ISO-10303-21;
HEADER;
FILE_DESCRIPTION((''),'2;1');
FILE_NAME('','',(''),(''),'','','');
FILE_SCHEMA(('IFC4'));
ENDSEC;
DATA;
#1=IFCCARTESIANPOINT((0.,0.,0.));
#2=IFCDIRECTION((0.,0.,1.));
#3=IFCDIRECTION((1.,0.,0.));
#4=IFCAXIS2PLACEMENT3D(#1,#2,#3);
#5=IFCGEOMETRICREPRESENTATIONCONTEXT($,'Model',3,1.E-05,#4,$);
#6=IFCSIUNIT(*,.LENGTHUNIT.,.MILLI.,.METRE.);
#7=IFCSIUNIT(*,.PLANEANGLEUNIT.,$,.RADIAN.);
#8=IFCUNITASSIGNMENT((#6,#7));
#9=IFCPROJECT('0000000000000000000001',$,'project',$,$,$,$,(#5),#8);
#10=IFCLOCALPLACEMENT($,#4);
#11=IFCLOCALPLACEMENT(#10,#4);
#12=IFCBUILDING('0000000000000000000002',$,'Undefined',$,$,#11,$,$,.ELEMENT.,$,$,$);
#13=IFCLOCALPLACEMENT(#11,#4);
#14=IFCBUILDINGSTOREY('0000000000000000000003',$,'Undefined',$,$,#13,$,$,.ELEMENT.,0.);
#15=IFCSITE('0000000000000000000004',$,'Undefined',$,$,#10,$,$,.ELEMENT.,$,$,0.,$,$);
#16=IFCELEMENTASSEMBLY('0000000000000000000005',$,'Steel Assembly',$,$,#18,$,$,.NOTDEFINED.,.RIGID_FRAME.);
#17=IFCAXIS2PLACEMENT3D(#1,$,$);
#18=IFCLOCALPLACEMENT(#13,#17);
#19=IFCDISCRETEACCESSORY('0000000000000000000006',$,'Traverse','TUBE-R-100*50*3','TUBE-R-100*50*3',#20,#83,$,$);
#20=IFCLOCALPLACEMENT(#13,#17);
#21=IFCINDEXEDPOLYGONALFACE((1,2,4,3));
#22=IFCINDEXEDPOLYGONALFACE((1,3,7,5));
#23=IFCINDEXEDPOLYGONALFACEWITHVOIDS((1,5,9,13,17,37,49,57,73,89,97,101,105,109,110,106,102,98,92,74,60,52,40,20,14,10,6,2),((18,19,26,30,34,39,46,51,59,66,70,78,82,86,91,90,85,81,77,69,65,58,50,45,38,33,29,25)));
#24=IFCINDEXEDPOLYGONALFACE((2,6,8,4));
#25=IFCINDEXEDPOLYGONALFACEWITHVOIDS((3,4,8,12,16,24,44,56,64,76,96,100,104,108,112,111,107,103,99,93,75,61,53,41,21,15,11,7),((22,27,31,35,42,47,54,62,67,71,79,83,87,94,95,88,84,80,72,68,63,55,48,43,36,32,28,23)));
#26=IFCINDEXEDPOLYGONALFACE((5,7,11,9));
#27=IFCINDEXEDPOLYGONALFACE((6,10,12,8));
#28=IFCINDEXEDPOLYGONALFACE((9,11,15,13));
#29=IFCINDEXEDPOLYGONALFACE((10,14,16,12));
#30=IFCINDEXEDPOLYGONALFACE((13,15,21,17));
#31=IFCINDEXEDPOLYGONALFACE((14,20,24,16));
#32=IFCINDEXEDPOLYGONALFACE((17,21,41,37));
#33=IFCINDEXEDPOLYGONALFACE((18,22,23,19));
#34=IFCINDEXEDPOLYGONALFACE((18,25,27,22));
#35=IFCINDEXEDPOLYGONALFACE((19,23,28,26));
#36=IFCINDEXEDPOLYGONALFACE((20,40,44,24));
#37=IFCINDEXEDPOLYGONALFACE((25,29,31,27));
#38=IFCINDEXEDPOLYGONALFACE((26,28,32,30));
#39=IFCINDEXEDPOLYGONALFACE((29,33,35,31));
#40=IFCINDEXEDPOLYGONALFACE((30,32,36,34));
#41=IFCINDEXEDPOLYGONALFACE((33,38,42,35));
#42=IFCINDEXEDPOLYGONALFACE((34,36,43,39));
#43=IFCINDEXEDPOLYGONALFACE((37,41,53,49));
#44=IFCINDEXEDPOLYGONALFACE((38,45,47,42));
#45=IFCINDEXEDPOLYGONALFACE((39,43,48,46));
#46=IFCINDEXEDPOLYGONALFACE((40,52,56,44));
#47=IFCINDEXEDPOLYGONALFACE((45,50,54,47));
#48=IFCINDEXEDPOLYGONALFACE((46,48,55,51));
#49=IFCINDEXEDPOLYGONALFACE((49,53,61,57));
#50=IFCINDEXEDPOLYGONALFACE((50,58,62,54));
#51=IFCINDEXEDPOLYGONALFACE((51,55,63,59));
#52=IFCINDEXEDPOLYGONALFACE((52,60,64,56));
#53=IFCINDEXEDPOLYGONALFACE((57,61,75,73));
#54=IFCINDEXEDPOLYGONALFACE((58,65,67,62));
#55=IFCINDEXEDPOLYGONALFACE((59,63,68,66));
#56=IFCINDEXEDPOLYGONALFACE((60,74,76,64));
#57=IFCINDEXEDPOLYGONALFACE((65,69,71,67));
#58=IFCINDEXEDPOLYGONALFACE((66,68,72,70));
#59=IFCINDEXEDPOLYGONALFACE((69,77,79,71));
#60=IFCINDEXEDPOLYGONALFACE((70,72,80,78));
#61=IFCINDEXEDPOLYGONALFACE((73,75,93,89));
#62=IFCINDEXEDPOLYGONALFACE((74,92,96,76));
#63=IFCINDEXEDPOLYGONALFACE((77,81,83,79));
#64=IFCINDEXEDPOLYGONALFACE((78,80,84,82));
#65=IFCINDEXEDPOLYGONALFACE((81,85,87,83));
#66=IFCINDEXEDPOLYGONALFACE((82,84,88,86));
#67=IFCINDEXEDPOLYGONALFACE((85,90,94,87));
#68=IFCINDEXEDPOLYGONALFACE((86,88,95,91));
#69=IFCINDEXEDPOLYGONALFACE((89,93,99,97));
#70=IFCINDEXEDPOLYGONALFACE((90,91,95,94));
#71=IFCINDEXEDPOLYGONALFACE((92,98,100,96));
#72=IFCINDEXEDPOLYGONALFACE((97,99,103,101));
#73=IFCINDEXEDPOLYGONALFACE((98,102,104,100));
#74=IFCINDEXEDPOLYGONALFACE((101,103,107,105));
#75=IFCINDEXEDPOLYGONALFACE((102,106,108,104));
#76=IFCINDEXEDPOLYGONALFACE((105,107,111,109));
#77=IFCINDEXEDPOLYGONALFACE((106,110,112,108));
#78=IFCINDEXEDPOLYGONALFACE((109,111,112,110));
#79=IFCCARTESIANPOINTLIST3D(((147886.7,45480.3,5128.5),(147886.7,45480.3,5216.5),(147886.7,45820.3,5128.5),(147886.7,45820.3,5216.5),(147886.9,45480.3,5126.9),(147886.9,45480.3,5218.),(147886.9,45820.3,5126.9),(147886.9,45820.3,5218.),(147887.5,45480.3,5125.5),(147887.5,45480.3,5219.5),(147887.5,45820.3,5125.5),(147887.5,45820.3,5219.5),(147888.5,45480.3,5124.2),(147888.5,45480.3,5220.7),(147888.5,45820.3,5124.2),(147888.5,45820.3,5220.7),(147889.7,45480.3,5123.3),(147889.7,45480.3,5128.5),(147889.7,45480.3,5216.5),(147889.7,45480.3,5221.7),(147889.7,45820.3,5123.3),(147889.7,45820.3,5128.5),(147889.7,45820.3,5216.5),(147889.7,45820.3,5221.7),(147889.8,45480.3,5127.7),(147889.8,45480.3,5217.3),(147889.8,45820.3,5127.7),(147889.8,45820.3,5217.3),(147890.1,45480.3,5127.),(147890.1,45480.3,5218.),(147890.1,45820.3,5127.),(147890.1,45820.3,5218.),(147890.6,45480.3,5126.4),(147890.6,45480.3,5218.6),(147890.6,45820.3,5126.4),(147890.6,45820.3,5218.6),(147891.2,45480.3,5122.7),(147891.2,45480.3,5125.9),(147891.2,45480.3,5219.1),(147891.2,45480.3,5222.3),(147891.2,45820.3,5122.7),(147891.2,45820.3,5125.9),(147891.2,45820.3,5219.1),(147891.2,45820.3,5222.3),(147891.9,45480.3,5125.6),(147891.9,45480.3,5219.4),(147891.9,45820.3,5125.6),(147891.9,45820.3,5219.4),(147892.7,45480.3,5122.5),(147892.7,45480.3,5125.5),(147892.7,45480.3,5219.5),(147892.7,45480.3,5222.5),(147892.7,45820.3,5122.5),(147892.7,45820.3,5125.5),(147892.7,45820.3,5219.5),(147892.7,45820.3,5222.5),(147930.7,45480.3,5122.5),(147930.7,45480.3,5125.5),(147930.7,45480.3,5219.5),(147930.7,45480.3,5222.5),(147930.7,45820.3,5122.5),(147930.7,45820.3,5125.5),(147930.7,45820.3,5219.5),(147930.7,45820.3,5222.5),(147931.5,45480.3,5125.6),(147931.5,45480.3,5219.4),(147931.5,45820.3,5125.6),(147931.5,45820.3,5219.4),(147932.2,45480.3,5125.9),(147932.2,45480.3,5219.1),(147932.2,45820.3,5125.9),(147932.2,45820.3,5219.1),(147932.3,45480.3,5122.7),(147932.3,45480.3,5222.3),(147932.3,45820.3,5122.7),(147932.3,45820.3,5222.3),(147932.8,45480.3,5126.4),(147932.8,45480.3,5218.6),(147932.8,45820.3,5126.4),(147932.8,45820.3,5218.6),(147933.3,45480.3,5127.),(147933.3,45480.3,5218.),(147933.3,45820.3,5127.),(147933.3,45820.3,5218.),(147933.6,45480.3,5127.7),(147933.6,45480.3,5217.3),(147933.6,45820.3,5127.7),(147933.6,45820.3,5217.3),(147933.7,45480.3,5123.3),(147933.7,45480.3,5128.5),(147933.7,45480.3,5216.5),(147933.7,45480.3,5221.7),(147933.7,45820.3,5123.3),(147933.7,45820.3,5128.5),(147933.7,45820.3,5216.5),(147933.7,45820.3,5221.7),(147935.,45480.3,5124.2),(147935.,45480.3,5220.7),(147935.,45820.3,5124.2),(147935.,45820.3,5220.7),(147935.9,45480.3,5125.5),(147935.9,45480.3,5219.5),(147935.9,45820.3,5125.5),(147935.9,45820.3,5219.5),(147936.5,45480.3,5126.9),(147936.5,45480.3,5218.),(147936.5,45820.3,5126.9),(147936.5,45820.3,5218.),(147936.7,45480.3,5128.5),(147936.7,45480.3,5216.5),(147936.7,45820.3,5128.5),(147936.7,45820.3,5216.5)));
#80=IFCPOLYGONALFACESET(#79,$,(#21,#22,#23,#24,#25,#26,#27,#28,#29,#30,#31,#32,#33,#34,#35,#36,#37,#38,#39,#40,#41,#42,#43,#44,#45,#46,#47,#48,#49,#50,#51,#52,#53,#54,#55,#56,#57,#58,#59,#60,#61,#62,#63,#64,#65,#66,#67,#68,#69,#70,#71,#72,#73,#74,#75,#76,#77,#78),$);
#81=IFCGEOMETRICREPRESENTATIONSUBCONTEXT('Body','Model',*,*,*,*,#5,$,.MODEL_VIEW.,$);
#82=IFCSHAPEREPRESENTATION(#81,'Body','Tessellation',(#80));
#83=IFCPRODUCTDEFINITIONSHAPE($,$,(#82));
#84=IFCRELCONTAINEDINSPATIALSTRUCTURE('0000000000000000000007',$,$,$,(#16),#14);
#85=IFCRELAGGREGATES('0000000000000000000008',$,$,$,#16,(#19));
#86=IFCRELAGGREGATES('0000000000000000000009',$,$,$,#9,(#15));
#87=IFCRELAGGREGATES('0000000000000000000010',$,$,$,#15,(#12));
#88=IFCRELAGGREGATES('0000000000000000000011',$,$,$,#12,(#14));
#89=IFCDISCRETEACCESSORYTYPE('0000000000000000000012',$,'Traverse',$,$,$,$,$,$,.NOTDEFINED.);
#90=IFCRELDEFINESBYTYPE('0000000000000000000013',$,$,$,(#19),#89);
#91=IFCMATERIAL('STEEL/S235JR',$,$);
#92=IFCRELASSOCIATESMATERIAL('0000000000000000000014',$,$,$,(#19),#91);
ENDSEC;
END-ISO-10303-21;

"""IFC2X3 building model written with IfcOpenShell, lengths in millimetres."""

from ifc_helpers import new_model, si_unit, frame, origin_with_axes, origin_2d_with_axis, place, context, subcontext, project, spatial, hollow_rectangle, extrude, material, type_object, element, aggregate, save


model = new_model("IFC2X3")

# Units and contexts
model_context = context("Model", 3, precision=1e-05, world=origin_with_axes())
body_context = subcontext(model_context, "Body", "Model", "MODEL_VIEW")
ifc_project = project(units=[si_unit("LENGTHUNIT", "METRE", prefix="MILLI"), si_unit("PLANEANGLEUNIT", "RADIAN")], contexts=[model_context])

# Site, building, storey
site_placement = place(None, origin_with_axes())
site = spatial("IfcSite", under=ifc_project, at=site_placement, Name="Undefined", CompositionType="ELEMENT", RefElevation=0.0)
building_placement = place(site_placement, origin_with_axes())
building = spatial("IfcBuilding", under=site, at=building_placement, Name="Undefined", CompositionType="ELEMENT")
storey_placement = place(building_placement, origin_with_axes())
storey = spatial("IfcBuildingStorey", under=building, at=storey_placement, Name="Undefined", CompositionType="ELEMENT", Elevation=0.0)

# Element assembly
ifc_material_1 = material(Name="STEEL/S235JR")
assembly_1_placement = place(storey_placement, origin_with_axes())
assembly_1 = element("IfcElementAssembly", 1, at=assembly_1_placement, inside=storey, Name="Steel Assembly", AssemblyPlace="NOTDEFINED", PredefinedType="RIGID_FRAME")

# Discrete accessory
discrete_accessory_type_1 = type_object("IfcDiscreteAccessoryType", Name="Traverse")
discrete_accessory_1_placement = place(assembly_1_placement, frame((147911.7, 45480.3, 5172.5), z_axis=(0.0, 0.0, 1.0), x_axis=(0.0, 1.0, 0.0)))
discrete_accessory_1 = element("IfcDiscreteAccessory", 2, at=discrete_accessory_1_placement, type_object=discrete_accessory_type_1, material=ifc_material_1, Name="Traverse", Description="TUBE-R-100*50*3", ObjectType="TUBE-R-100*50*3", context=body_context, shape_type="SweptSolid", body=[
    extrude(hollow_rectangle(XDim=50.0, YDim=100.0, WallThickness=3.0, InnerFilletRadius=3.0, OuterFilletRadius=6.0, at=origin_2d_with_axis()), frame((340.0, 0.0, 0.0), z_axis=(-1.0, 0.0, 0.0), x_axis=(0.0, -1.0, 0.0)), (0.0, 0.0, 1.0), 340.0),
])

aggregate(assembly_1, [discrete_accessory_1])

save(model, "model.ifc")
